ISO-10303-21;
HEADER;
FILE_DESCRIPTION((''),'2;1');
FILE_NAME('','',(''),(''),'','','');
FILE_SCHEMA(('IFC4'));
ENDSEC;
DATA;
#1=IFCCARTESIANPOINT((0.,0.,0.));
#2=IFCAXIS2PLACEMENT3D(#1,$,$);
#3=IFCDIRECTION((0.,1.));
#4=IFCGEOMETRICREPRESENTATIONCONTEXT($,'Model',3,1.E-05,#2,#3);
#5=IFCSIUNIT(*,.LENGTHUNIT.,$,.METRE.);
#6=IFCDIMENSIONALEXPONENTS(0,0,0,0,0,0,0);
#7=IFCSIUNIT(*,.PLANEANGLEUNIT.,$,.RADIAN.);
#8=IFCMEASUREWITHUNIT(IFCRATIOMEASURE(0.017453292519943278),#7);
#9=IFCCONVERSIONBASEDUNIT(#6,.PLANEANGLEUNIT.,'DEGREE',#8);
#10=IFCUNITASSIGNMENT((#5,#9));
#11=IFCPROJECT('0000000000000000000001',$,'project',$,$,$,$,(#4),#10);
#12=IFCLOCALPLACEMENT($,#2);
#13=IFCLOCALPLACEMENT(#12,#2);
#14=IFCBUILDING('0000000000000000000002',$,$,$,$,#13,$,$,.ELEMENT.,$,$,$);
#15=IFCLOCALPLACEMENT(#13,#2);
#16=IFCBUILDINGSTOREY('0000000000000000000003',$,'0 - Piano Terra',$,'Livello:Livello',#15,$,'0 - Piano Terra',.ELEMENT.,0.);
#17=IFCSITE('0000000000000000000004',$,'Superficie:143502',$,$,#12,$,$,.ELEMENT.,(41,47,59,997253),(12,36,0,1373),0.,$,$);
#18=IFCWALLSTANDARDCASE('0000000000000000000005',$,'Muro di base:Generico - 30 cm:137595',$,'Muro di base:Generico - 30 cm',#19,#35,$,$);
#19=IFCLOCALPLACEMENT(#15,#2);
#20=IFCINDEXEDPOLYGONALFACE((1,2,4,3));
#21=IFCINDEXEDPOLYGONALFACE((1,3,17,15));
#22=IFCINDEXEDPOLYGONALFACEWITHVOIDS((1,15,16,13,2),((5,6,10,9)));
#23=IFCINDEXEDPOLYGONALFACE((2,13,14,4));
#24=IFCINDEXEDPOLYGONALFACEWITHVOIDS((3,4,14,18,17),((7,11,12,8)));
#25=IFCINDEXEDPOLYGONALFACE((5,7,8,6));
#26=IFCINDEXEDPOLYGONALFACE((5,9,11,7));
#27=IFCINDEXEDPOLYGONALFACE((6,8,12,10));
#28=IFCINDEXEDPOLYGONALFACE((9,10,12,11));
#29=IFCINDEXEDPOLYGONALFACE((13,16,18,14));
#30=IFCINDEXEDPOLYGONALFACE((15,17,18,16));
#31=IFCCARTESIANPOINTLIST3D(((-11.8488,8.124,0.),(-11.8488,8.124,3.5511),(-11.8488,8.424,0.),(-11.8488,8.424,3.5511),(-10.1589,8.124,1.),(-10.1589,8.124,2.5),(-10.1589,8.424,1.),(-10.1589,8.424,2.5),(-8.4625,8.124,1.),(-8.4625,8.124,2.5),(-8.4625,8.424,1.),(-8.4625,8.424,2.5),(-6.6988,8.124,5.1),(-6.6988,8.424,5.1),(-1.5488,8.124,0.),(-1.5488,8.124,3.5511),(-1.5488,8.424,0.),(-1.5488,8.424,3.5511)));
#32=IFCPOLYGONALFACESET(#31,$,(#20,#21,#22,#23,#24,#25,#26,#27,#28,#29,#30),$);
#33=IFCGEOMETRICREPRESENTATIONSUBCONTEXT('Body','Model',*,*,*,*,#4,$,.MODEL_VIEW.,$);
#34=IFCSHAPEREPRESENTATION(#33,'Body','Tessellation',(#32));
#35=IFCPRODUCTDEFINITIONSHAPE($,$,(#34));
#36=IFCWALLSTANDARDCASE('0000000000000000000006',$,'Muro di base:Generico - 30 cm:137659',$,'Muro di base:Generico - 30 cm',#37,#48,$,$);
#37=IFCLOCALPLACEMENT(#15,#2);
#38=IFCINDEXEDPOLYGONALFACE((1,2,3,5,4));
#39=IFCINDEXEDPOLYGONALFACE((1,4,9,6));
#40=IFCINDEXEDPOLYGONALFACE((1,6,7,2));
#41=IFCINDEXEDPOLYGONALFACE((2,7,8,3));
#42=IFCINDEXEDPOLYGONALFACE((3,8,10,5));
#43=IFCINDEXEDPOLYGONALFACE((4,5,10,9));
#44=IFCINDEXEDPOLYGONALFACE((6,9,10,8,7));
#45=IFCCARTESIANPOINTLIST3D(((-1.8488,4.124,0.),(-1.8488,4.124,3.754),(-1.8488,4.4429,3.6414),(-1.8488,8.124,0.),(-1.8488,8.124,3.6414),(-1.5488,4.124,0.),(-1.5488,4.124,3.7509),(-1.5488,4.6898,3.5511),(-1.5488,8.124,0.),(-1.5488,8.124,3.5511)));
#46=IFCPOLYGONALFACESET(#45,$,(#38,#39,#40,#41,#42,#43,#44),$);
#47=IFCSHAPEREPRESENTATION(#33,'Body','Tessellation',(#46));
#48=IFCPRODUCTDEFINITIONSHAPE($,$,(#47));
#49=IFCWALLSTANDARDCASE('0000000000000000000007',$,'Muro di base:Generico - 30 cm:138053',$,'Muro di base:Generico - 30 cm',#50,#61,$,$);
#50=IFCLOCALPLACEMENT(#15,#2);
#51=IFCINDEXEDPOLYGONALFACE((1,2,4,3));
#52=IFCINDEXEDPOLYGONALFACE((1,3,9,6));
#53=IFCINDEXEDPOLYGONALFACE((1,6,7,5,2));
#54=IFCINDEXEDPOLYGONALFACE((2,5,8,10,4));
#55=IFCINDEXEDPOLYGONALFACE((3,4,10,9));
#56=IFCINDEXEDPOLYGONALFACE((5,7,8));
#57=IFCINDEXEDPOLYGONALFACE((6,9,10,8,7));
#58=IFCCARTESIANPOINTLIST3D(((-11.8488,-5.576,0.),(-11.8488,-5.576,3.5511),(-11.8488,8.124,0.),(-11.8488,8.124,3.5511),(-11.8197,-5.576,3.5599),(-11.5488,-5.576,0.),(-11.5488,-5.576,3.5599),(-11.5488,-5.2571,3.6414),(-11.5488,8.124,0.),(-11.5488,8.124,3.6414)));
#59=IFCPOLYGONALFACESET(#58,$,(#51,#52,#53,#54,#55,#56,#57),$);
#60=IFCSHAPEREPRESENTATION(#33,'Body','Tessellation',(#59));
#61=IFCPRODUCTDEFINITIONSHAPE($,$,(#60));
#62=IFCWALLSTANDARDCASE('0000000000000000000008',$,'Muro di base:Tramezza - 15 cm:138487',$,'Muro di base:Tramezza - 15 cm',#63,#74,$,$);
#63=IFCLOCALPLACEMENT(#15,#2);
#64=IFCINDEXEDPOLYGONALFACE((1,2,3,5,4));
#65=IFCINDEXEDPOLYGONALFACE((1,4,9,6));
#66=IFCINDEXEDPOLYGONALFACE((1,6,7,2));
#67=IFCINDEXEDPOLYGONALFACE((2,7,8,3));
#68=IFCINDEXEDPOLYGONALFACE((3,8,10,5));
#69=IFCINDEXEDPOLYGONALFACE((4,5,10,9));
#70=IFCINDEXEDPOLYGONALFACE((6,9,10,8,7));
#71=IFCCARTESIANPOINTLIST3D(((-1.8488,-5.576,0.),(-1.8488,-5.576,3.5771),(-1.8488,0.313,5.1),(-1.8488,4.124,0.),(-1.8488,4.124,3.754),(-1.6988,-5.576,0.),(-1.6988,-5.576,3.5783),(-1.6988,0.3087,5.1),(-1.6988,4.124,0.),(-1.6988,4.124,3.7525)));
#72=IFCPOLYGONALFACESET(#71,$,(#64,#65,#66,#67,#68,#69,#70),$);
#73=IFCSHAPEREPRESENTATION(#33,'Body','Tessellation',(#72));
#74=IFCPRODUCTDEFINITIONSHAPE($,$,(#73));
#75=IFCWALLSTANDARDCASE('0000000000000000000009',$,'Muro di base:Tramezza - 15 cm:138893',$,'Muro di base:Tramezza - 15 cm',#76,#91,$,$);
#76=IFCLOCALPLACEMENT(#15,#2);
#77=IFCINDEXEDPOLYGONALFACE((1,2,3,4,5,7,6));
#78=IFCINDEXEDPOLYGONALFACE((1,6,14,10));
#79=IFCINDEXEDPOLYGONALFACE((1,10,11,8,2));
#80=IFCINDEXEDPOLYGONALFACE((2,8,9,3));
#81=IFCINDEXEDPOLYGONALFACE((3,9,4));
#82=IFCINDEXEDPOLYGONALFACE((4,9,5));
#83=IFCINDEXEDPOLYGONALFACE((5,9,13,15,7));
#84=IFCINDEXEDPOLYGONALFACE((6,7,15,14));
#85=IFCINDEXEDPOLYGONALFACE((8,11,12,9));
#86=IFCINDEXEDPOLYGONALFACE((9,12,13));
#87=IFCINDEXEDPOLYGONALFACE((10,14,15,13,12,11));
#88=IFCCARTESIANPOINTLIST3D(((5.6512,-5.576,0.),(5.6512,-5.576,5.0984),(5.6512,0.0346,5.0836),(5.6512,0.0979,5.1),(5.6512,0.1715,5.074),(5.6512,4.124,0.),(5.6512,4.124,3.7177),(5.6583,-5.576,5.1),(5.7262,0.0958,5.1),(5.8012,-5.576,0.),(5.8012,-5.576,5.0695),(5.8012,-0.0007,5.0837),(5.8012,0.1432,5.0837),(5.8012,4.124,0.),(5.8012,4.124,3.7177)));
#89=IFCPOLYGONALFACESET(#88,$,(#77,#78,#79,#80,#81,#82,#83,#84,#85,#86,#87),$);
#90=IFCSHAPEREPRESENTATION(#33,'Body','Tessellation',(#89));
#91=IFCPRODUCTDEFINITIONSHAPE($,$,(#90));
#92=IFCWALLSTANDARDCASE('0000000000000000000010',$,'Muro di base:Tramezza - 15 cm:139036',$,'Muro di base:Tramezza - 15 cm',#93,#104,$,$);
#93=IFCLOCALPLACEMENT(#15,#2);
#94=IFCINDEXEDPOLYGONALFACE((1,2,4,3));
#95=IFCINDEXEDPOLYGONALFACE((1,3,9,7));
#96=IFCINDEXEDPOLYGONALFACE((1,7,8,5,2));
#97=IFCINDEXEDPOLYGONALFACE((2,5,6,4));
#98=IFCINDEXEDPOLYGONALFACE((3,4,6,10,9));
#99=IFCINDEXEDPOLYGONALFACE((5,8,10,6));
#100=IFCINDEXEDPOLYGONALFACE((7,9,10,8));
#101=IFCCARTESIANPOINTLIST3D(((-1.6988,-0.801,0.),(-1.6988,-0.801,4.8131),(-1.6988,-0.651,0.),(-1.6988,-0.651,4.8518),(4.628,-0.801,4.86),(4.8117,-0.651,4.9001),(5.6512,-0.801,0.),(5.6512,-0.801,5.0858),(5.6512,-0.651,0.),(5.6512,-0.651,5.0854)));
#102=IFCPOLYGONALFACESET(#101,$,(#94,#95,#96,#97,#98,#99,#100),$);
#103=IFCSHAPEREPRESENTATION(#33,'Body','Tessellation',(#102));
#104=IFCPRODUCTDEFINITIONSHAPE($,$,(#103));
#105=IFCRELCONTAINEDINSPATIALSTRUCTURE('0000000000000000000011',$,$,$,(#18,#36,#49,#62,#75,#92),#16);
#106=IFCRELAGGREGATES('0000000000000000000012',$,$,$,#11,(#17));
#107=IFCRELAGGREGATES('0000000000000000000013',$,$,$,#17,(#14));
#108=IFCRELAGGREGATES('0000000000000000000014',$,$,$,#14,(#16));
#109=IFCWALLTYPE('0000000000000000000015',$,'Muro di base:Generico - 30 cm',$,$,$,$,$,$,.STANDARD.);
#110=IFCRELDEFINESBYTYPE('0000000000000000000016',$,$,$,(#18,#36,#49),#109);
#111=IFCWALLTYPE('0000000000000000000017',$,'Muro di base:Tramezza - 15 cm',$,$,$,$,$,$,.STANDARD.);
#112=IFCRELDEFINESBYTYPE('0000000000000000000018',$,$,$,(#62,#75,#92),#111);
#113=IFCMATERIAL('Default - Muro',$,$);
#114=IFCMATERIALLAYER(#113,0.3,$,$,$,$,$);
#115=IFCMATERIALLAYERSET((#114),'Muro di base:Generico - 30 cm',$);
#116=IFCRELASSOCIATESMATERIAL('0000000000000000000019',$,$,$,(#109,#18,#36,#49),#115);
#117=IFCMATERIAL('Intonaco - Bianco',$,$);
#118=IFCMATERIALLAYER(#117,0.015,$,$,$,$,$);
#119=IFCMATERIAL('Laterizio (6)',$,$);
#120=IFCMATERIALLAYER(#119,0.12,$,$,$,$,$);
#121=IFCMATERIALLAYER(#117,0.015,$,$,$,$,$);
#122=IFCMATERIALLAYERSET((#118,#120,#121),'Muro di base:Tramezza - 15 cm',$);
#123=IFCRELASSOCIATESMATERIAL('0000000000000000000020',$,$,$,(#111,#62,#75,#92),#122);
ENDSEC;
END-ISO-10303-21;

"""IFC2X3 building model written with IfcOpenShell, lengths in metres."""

from ifc_helpers import new_model, entity, si_unit, converted_unit, direction, frame, frame_2d, origin, place, context, subcontext, project, spatial, polyline, rectangle, extrude, clip, bounded_halfspace, material, layer, layer_set, layer_usage, type_object, element, save


model = new_model("IFC2X3")

# Units and contexts
model_context = context("Model", 3, precision=1e-05, world=origin(), true_north=direction((0.0, 1.0)))
body_context = subcontext(model_context, "Body", "Model", "MODEL_VIEW")
ifc_project = project(units=[si_unit("LENGTHUNIT", "METRE"), converted_unit("PLANEANGLEUNIT", "DEGREE", entity("IfcRatioMeasure", 0.017453292519943278), si_unit("PLANEANGLEUNIT", "RADIAN"), dimensions=[0, 0, 0, 0, 0, 0, 0])], contexts=[model_context])

# Site, building, storey
site_placement = place(None, origin())
site = spatial("IfcSite", under=ifc_project, at=site_placement, Name="Superficie:143502", CompositionType="ELEMENT", RefLatitude=(41, 47, 59, 997253), RefLongitude=(12, 36, 0, 1373), RefElevation=0.0)
building_placement = place(site_placement, origin())
building = spatial("IfcBuilding", under=site, at=building_placement, CompositionType="ELEMENT")
storey_placement = place(building_placement, origin())
storey = spatial("IfcBuildingStorey", under=building, at=storey_placement, Name="0 - Piano Terra", ObjectType="Livello:Livello", LongName="0 - Piano Terra", CompositionType="ELEMENT", Elevation=0.0)

# Shared definitions
ifc_material_1 = material(Name="Intonaco - Bianco")

# Wall, opening
ifc_material_2 = material(Name="Default - Muro")
ifc_layer_1 = layer(ifc_material_2, 0.3)
ifc_layer_set_1 = layer_set([ifc_layer_1], Name="Muro di base:Generico - 30 cm")
ifc_layer_usage_1 = layer_usage(ifc_layer_set_1, "AXIS2", "NEGATIVE", 0.15)
wall_type_1 = type_object("IfcWallType", Name="Muro di base:Generico - 30 cm", PredefinedType="STANDARD", material=ifc_layer_set_1)
wall_1_placement = place(storey_placement, frame((-11.8488, 8.274, 0.0)))
wall_1 = element("IfcWallStandardCase", 1, at=wall_1_placement, inside=storey, type_object=wall_type_1, material=ifc_layer_usage_1, Name="Muro di base:Generico - 30 cm:137595", ObjectType="Muro di base:Generico - 30 cm", context=body_context, shape_type="Clipping", body=[
    clip(clip(extrude(rectangle(XDim=10.3, YDim=0.3, at=frame_2d((5.15, 0.0), x_axis=(-1.0, 0.0))), origin(), (0.0, 0.0, 1.0), 5.1), bounded_halfspace(frame((0.0, -0.15, 3.5511), z_axis=(-0.288008, 0.0, 0.957628), x_axis=(0.0, -1.0, 0.0)), False, frame((0.0, -0.15, 3.5511)), polyline([(0.0, 0.0), (0.3, 0.0), (5.075, 0.0), (5.15, 0.0), (5.15, 0.3), (0.0, 0.3), (0.0, 0.0)]))), bounded_halfspace(frame((5.15, -0.15, 5.1), z_axis=(0.288008, 0.0, 0.957628), x_axis=(0.0, 1.0, 0.0)), False, frame((5.15, -0.15, 5.1)), polyline([(0.0, 0.0), (0.075, 0.0), (4.85, 0.0), (5.15, 0.0), (5.15, 0.3), (0.0, 0.3), (0.0, 0.0)]))),
])
opening_1_placement = place(wall_1_placement, frame((1.6899, -0.15, 1.0)))
element("IfcOpeningElement", 2, at=opening_1_placement, cuts=wall_1, ObjectType="Opening", context=body_context, shape_type="SweptSolid", body=[
    extrude(rectangle(XDim=1.5, YDim=1.6964, at=frame_2d((0.0, 0.0), x_axis=(1.0, 0.0))), frame((0.8482, 0.0, 0.75), z_axis=(0.0, 1.0, 0.0), x_axis=(0.0, 0.0, -1.0)), (0.0, 0.0, 1.0), 0.3),
])

# Walls
ifc_layer_usage_2 = layer_usage(ifc_layer_set_1, "AXIS2", "NEGATIVE", 0.15)
wall_2_placement = place(storey_placement, frame((-1.6988, 8.124, 0.0), z_axis=(0.0, 0.0, 1.0), x_axis=(0.0, -1.0, 0.0)))
element("IfcWallStandardCase", 3, at=wall_2_placement, inside=storey, type_object=wall_type_1, material=ifc_layer_usage_2, Name="Muro di base:Generico - 30 cm:137659", ObjectType="Muro di base:Generico - 30 cm", context=body_context, shape_type="Clipping", body=[
    clip(clip(extrude(rectangle(XDim=4.0, YDim=0.3, at=frame_2d((2.0, 0.0), x_axis=(-1.0, 0.0))), origin(), (0.0, 0.0, 1.0), 3.754), bounded_halfspace(frame((0.0, -0.15, 3.6414), z_axis=(0.0, 0.288008, 0.957628), x_axis=(-1.0, 0.0, 0.0)), False, frame((0.0, -0.15, 3.6414)), polyline([(0.0, 0.0), (3.6811, 0.0), (3.4343, 0.3), (0.0, 0.3), (0.0, 0.0)]))), bounded_halfspace(frame((3.6811, -0.15, 3.6414), z_axis=(-0.333014, 0.009548, 0.942873), x_axis=(0.618926, -0.752168, 0.226216)), False, frame((3.6811, -0.15, 3.6414)), polyline([(0.0, 0.0), (0.3189, 0.0), (0.3189, 0.15), (0.3189, 0.3), (0.0189, 0.3), (-0.2469, 0.3), (0.0, 0.0)]))),
])
ifc_layer_usage_3 = layer_usage(ifc_layer_set_1, "AXIS2", "NEGATIVE", 0.15)
wall_3_placement = place(storey_placement, frame((-11.6988, -5.576, 0.0), z_axis=(0.0, 0.0, 1.0), x_axis=(0.0, 1.0, 0.0)))
element("IfcWallStandardCase", 4, at=wall_3_placement, inside=storey, type_object=wall_type_1, material=ifc_layer_usage_3, Name="Muro di base:Generico - 30 cm:138053", ObjectType="Muro di base:Generico - 30 cm", context=body_context, shape_type="Clipping", body=[
    clip(clip(extrude(rectangle(XDim=13.7, YDim=0.3, at=frame_2d((6.85, 0.0), x_axis=(-1.0, 0.0))), origin(), (0.0, 0.0, 1.0), 3.6414), bounded_halfspace(frame((0.3189, -0.15, 3.6414), z_axis=(0.0, 0.288008, 0.957628), x_axis=(-1.0, 0.0, 0.0)), False, frame((0.3189, -0.15, 3.6414)), polyline([(0.0, 0.0), (13.3811, 0.0), (13.3811, 0.3), (-0.3189, 0.3), (-0.3189, 0.2709), (0.0, 0.0)]))), bounded_halfspace(frame((0.0, -0.15, 3.5599), z_axis=(-0.247541, 0.0, 0.968877), x_axis=(0.0, -1.0, 0.0)), False, frame((0.0, -0.15, 3.5599)), polyline([(0.0, 0.0), (0.3189, 0.0), (0.0, 0.2709), (0.0, 0.0)]))),
])

# Walls
ifc_layer_2 = layer(ifc_material_1, 0.015)
ifc_material_3 = material(Name="Laterizio (6)")
ifc_layer_3 = layer(ifc_material_3, 0.12)
ifc_layer_4 = layer(ifc_material_1, 0.015)
ifc_layer_set_2 = layer_set([ifc_layer_2, ifc_layer_3, ifc_layer_4], Name="Muro di base:Tramezza - 15 cm")
ifc_layer_usage_4 = layer_usage(ifc_layer_set_2, "AXIS2", "NEGATIVE", 0.075)
wall_type_2 = type_object("IfcWallType", Name="Muro di base:Tramezza - 15 cm", PredefinedType="STANDARD", material=ifc_layer_set_2)
wall_4_placement = place(storey_placement, frame((-1.7738, 4.124, 0.0), z_axis=(0.0, 0.0, 1.0), x_axis=(0.0, -1.0, 0.0)))
element("IfcWallStandardCase", 5, at=wall_4_placement, inside=storey, type_object=wall_type_2, material=ifc_layer_usage_4, Name="Muro di base:Tramezza - 15 cm:138487", ObjectType="Muro di base:Tramezza - 15 cm", context=body_context, shape_type="Clipping", body=[
    clip(clip(extrude(rectangle(XDim=9.7, YDim=0.15, at=frame_2d((4.85, 0.0), x_axis=(-1.0, 0.0))), origin(), (0.0, 0.0, 1.0), 5.1), bounded_halfspace(frame((3.8111, -0.075, 5.1), z_axis=(0.250353, -0.007178, 0.968128), x_axis=(-0.623622, 0.763695, 0.166928)), False, frame((3.8111, -0.075, 5.1)), polyline([(0.0, 0.0), (5.8889, 0.0), (5.8889, 0.15), (1.1139, 0.15), (0.9639, 0.15), (0.0043, 0.15), (0.0, 0.0)]))), bounded_halfspace(frame((0.0, -0.075, 3.754), z_axis=(-0.333014, 0.009548, 0.942873), x_axis=(0.618926, -0.752168, 0.226216)), False, frame((0.0, -0.075, 3.754)), polyline([(0.0, 0.0), (3.8111, 0.0), (3.8154, 0.15), (0.0, 0.15), (0.0, 0.0)]))),
])
ifc_layer_usage_5 = layer_usage(ifc_layer_set_2, "AXIS2", "NEGATIVE", 0.075)
wall_5_placement = place(storey_placement, frame((5.7262, 4.124, 0.0), z_axis=(0.0, 0.0, 1.0), x_axis=(0.0, -1.0, 0.0)))
element("IfcWallStandardCase", 6, at=wall_5_placement, inside=storey, type_object=wall_type_2, material=ifc_layer_usage_5, Name="Muro di base:Tramezza - 15 cm:138893", ObjectType="Muro di base:Tramezza - 15 cm", context=body_context, shape_type="Clipping", body=[
    clip(clip(clip(clip(clip(clip(extrude(rectangle(XDim=9.7, YDim=0.15, at=frame_2d((4.85, 0.0), x_axis=(-1.0, 0.0))), origin(), (0.0, 0.0, 1.0), 5.1), bounded_halfspace(frame((4.0261, -0.075, 5.1), z_axis=(0.250353, -0.007178, 0.968128), x_axis=(-0.623622, 0.763695, 0.166928)), False, frame((4.0261, -0.075, 5.1)), polyline([(0.0, 0.0), (0.0634, 0.0), (0.0022, 0.075), (0.0, 0.0)]))), bounded_halfspace(frame((3.9526, -0.075, 5.074), z_axis=(-0.333014, 0.009548, 0.942873), x_axis=(0.618926, -0.752168, 0.226216)), False, frame((3.9526, -0.075, 5.074)), polyline([(0.0, 0.0), (0.0735, 0.0), (0.0757, 0.075), (0.0, 0.0)]))), bounded_halfspace(frame((4.1248, 0.075, 5.0837), z_axis=(0.0, 0.21188, 0.977296), x_axis=(-1.0, 0.0, 0.0)), False, frame((4.1248, 0.075, 5.0837)), polyline([(0.0, 0.0), (-0.1439, 0.0), (-0.0965, -0.075), (0.0, 0.0)]))), bounded_halfspace(frame((0.0, -0.075, 3.7177), z_axis=(-0.324578, 0.0, 0.945859), x_axis=(0.0, -1.0, 0.0)), False, frame((0.0, -0.075, 3.7177)), polyline([(0.0, 0.0), (3.9526, 0.0), (4.0282, 0.075), (3.9809, 0.15), (0.0, 0.15), (0.0, 0.0)]))), bounded_halfspace(frame((9.7, -0.0679, 5.1), z_axis=(0.002501, 0.208804, 0.977954), x_axis=(-0.782734, -0.608227, 0.131865)), False, frame((9.7, -0.0679, 5.1)), polyline([(0.0, 0.0), (0.0, 0.1429), (-5.5752, 0.1429), (-5.6718, 0.0679), (0.0, 0.0)]))), bounded_halfspace(frame((4.0895, -0.075, 5.0836), z_axis=(-0.002581, -0.215548, 0.97649), x_axis=(-0.092333, 0.972373, 0.214396)), False, frame((4.0895, -0.075, 5.0836)), polyline([(0.0, 0.0), (0.6855, 0.0), (0.8355, 0.0), (5.6105, 0.0), (5.6105, 0.0071), (-0.0612, 0.075), (0.0, 0.0)]))),
])
ifc_layer_usage_6 = layer_usage(ifc_layer_set_2, "AXIS2", "NEGATIVE", 0.075)
wall_6_placement = place(storey_placement, frame((5.6512, -0.726, 0.0), z_axis=(0.0, 0.0, 1.0), x_axis=(-1.0, 0.0, 0.0)))
element("IfcWallStandardCase", 7, at=wall_6_placement, inside=storey, type_object=wall_type_2, material=ifc_layer_usage_6, Name="Muro di base:Tramezza - 15 cm:139036", ObjectType="Muro di base:Tramezza - 15 cm", context=body_context, shape_type="Clipping", body=[
    clip(clip(extrude(rectangle(XDim=7.35, YDim=0.15, at=frame_2d((3.675, 0.0), x_axis=(-1.0, 0.0))), origin(), (0.0, 0.0, 1.0), 5.0858), bounded_halfspace(frame((0.8395, -0.075, 4.9001), z_axis=(0.007178, 0.250353, 0.968128), x_axis=(-0.763695, -0.623622, 0.166928)), False, frame((0.8395, -0.075, 4.9001)), polyline([(0.0, 0.0), (6.5105, 0.0), (6.5105, 0.15), (0.1837, 0.15), (0.0, 0.0)]))), bounded_halfspace(frame((0.0, -0.075, 5.0854), z_axis=(0.215548, -0.002581, 0.97649), x_axis=(-0.972373, -0.092333, 0.214396)), False, frame((0.0, -0.075, 5.0854)), polyline([(0.0, 0.0), (0.8395, 0.0), (1.0232, 0.15), (0.0, 0.15), (0.0, 0.0)]))),
])

save(model, "model.ifc")
